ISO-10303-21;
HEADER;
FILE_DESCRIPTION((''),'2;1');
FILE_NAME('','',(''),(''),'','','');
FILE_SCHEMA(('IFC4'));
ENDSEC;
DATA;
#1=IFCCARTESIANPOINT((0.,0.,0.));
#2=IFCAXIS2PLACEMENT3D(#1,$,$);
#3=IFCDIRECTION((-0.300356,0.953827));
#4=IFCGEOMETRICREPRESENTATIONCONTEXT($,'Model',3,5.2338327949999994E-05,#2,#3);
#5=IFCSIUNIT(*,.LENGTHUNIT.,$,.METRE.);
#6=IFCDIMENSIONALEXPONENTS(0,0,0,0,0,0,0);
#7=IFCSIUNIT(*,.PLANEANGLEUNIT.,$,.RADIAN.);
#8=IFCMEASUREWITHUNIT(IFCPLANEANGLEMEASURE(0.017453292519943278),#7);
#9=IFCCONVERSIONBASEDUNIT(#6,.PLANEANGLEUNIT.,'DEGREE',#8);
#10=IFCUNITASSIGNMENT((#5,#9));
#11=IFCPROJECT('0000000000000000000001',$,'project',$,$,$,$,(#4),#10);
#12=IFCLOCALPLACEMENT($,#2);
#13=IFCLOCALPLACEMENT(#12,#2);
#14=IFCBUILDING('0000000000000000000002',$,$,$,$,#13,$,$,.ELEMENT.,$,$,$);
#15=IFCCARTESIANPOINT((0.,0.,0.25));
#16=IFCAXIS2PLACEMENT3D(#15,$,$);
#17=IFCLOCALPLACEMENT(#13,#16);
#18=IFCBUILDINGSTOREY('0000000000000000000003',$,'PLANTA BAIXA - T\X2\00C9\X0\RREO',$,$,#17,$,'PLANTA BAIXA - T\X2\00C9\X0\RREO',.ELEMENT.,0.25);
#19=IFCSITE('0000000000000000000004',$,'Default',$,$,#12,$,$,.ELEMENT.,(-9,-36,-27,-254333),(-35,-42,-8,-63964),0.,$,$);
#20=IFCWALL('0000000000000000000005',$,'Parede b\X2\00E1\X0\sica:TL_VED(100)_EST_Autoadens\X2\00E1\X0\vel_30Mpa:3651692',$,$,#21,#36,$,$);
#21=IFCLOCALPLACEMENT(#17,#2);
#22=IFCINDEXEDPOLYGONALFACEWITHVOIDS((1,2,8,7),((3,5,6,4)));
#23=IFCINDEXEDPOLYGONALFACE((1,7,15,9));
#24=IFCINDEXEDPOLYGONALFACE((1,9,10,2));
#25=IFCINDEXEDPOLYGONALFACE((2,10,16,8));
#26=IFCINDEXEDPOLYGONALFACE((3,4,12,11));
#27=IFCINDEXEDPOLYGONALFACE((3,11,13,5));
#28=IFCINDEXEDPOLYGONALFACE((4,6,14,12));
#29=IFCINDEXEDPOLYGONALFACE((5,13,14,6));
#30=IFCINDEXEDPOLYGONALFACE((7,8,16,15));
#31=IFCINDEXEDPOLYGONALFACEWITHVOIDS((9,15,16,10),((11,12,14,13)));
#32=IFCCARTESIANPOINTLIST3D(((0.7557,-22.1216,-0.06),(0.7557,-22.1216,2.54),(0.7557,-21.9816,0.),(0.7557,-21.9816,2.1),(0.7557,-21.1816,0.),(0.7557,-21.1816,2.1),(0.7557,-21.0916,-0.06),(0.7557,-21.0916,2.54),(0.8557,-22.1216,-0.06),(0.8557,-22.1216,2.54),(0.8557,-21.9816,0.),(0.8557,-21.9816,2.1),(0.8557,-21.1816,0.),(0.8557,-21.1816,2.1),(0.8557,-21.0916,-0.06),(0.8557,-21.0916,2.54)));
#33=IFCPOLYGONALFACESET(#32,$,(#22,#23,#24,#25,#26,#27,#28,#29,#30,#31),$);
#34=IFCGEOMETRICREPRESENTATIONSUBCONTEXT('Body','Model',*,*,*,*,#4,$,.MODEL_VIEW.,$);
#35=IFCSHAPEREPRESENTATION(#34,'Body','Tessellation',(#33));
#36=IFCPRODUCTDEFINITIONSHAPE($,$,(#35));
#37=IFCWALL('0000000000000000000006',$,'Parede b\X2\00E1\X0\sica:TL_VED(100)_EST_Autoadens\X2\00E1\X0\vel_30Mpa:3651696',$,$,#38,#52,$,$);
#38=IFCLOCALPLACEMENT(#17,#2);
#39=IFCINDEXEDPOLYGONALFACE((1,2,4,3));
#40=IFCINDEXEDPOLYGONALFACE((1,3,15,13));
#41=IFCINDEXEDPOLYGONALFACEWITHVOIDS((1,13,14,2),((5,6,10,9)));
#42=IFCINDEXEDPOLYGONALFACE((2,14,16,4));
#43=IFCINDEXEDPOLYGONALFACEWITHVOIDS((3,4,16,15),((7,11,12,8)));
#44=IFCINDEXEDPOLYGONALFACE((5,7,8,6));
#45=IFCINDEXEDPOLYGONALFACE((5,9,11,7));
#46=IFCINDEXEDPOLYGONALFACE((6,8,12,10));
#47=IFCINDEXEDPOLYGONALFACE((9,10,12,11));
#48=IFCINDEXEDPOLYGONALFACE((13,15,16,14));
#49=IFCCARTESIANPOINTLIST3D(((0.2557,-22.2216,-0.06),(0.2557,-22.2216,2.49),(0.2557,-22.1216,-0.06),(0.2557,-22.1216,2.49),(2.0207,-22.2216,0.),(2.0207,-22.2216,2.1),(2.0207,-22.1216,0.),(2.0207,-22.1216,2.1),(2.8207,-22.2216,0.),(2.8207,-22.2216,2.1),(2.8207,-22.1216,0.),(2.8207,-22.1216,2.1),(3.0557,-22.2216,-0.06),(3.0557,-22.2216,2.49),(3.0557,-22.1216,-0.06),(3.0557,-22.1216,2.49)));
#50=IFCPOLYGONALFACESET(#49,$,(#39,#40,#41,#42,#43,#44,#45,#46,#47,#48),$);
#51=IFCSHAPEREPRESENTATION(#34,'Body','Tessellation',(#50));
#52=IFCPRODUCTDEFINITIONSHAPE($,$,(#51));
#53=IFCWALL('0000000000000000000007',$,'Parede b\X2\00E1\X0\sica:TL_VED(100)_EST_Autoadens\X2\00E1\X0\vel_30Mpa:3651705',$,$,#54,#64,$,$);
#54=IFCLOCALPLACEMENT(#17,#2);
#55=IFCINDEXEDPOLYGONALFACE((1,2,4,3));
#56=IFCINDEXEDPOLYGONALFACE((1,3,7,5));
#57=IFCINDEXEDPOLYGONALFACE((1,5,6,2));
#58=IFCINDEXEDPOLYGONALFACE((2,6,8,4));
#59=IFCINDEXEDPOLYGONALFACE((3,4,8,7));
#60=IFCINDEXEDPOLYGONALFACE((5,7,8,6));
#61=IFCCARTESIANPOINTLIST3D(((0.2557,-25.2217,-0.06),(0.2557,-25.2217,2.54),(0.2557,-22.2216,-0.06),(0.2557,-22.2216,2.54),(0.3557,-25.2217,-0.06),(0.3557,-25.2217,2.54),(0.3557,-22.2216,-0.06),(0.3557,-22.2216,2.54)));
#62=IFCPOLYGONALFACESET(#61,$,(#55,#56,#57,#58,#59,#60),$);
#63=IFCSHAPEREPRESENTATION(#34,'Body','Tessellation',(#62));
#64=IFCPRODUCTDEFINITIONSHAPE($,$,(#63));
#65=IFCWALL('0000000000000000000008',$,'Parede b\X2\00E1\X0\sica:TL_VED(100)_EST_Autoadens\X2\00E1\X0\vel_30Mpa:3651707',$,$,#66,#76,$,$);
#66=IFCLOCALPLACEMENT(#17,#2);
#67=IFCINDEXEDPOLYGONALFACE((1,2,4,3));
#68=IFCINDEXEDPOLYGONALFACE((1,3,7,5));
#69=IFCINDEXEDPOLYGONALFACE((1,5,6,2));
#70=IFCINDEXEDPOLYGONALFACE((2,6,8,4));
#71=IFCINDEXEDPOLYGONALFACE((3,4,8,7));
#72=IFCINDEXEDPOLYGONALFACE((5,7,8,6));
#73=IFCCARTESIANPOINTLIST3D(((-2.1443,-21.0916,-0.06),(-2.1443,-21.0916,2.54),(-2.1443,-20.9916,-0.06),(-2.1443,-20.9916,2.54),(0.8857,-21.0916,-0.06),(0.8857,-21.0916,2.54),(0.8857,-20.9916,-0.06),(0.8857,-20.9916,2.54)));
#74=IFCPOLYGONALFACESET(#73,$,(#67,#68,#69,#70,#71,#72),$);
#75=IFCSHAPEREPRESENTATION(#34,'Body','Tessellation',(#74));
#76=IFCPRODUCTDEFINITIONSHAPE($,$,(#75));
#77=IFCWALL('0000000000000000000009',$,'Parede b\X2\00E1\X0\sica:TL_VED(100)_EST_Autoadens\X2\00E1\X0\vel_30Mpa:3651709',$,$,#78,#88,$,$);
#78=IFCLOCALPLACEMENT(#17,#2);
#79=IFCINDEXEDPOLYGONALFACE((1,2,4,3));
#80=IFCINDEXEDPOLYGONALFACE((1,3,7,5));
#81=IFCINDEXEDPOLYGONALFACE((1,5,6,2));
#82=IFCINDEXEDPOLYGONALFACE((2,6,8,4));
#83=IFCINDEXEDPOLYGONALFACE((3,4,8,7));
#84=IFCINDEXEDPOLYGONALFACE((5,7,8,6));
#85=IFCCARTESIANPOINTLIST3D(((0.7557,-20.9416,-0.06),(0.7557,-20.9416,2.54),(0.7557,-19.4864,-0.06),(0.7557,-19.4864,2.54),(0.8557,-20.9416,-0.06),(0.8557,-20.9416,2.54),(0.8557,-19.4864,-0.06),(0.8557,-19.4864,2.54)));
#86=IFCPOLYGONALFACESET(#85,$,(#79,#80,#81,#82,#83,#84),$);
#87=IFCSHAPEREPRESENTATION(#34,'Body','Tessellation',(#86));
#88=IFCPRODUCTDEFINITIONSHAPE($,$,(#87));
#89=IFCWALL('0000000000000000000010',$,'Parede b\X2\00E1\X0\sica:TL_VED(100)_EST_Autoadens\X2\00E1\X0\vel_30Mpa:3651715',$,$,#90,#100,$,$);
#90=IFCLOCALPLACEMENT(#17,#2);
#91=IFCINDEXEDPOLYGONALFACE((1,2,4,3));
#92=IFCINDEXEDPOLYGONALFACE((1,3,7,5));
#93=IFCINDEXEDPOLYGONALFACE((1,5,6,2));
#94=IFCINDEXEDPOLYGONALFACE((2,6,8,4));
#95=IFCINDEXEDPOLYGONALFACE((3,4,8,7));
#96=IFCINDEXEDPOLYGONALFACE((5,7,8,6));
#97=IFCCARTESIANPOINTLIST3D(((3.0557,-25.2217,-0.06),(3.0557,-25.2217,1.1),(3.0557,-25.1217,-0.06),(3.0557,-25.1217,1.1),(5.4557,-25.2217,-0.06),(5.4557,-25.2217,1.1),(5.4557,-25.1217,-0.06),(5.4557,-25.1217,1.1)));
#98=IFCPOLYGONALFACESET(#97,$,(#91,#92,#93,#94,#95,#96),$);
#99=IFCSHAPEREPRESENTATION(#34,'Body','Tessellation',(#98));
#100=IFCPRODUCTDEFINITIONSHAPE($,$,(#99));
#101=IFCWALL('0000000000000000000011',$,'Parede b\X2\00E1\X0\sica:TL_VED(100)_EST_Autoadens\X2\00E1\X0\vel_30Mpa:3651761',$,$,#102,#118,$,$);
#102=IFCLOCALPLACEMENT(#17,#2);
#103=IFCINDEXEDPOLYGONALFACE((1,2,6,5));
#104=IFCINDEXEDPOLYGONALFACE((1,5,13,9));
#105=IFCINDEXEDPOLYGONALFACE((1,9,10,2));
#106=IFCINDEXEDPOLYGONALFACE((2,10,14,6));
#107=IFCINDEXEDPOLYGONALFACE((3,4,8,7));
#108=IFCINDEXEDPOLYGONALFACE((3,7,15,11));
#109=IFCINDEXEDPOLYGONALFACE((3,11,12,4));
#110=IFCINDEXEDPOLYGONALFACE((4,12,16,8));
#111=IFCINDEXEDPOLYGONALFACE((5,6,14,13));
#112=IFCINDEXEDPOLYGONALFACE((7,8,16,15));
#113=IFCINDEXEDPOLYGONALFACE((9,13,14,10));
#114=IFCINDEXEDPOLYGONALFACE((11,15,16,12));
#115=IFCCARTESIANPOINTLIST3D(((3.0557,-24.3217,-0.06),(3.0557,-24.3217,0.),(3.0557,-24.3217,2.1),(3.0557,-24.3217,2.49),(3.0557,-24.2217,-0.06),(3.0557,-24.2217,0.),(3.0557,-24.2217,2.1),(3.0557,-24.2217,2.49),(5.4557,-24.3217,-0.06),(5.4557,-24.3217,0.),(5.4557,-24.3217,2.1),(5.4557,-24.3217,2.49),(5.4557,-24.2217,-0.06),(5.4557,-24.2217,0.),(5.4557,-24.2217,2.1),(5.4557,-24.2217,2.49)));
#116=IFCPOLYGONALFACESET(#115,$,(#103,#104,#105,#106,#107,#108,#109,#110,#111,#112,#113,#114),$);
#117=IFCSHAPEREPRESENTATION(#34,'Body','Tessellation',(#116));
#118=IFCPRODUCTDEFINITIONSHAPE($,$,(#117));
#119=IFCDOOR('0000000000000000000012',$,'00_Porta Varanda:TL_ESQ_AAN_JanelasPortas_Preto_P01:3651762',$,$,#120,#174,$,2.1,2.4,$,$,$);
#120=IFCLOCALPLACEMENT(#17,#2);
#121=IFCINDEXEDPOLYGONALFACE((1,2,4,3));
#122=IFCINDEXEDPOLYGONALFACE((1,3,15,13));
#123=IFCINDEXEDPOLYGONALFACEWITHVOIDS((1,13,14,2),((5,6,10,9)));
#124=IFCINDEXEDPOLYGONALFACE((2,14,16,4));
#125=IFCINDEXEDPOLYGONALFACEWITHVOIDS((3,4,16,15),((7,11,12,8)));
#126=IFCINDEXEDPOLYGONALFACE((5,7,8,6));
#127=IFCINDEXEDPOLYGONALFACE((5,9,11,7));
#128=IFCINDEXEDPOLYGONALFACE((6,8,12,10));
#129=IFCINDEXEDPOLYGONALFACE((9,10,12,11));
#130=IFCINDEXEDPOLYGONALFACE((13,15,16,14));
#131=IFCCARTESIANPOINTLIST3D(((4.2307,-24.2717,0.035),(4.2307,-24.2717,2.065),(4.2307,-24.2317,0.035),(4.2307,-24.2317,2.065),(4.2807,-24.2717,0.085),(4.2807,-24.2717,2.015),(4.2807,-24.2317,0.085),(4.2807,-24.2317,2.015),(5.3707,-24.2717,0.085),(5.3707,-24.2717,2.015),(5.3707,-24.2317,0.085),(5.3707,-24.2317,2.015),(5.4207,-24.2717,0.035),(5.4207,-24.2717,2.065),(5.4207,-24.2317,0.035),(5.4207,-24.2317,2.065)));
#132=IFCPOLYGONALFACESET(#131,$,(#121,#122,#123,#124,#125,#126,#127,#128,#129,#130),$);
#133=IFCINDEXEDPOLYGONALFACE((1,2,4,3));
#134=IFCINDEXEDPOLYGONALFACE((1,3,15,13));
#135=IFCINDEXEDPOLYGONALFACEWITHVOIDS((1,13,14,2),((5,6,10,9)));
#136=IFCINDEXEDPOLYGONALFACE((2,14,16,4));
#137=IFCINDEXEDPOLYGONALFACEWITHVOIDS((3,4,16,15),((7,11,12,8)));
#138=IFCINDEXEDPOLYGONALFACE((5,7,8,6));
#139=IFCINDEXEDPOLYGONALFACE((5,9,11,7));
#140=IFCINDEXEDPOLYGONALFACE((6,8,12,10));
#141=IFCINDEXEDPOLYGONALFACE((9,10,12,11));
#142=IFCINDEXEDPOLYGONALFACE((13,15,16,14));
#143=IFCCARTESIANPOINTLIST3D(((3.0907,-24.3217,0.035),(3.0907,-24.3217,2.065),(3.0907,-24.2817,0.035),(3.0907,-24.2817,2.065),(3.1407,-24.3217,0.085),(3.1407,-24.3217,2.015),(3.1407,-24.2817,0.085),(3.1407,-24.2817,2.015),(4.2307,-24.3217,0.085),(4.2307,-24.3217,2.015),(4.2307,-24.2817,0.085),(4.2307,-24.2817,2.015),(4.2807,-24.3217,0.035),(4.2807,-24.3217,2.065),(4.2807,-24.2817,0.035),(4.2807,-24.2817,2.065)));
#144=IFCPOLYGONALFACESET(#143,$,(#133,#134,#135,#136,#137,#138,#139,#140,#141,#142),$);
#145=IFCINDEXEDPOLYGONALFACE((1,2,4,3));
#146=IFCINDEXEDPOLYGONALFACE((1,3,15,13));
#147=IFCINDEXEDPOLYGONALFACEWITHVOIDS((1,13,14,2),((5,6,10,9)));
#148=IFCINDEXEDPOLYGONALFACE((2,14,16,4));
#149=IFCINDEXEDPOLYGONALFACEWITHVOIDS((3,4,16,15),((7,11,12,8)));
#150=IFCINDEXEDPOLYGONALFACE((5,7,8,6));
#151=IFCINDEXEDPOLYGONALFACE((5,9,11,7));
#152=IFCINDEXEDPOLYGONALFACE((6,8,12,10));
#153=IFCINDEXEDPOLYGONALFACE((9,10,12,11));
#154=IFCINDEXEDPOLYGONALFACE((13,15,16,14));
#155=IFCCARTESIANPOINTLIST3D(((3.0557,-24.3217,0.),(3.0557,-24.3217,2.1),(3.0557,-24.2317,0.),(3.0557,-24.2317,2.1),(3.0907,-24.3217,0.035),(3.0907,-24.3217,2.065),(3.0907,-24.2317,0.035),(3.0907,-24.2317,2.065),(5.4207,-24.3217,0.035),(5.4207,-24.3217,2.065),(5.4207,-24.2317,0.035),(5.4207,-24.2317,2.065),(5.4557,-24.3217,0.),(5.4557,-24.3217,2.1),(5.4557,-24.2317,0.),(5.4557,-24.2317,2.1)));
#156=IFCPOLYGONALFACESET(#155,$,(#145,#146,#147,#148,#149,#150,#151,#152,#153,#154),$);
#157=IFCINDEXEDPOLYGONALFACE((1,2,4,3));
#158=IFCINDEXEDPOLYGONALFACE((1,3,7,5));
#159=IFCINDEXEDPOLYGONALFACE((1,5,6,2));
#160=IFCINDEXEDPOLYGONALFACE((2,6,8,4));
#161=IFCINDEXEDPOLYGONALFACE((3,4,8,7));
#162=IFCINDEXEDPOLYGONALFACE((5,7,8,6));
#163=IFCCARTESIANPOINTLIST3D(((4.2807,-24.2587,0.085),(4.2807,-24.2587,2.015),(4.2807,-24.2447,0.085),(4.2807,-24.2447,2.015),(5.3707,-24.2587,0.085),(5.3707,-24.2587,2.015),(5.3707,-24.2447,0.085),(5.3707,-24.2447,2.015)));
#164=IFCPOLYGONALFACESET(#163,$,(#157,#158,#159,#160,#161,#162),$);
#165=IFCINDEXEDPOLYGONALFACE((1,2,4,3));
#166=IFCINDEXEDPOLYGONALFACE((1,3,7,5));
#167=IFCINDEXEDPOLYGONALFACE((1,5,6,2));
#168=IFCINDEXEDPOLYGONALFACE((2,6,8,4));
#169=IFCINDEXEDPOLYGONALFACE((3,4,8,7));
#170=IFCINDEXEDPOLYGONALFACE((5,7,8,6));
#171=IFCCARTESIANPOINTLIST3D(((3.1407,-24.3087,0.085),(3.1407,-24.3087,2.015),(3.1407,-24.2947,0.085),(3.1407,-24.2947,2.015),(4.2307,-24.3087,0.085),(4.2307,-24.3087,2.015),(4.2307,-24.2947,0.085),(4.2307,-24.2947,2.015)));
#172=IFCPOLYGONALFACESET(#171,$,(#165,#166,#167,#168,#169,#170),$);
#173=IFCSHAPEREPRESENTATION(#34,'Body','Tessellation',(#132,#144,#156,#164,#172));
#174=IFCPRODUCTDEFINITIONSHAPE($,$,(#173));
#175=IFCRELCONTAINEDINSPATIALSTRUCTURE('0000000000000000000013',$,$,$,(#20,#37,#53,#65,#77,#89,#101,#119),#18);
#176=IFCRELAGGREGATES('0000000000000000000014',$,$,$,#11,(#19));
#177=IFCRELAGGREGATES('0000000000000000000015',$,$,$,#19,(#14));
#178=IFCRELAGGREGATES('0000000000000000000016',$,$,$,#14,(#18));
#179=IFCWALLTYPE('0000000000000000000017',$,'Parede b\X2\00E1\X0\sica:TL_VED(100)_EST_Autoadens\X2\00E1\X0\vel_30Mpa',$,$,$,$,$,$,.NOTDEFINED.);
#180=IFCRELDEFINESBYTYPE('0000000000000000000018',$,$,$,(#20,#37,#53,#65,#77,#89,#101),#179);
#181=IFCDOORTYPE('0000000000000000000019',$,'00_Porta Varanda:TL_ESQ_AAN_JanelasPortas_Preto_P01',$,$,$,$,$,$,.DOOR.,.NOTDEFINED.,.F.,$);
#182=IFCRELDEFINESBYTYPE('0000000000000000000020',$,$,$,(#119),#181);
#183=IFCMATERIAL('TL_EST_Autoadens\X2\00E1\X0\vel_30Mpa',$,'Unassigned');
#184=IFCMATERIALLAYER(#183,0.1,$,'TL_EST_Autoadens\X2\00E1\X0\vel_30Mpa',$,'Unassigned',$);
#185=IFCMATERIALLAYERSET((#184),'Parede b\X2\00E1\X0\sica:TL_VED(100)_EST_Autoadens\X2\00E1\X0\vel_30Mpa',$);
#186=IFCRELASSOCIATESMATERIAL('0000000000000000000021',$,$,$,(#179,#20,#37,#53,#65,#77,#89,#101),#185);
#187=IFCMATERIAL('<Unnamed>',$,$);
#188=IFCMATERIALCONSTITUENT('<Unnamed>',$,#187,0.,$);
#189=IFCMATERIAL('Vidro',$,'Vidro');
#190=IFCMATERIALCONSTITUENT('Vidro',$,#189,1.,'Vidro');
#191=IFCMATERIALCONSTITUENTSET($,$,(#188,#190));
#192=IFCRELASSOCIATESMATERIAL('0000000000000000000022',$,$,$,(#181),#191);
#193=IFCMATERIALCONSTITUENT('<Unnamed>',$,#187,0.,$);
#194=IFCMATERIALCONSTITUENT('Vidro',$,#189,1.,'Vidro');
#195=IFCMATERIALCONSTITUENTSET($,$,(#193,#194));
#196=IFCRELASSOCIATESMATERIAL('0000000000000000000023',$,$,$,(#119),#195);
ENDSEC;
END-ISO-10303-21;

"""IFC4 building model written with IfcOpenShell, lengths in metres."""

from ifc_helpers import new_model, entity, si_unit, converted_unit, direction, frame, frame_2d, origin, place, context, subcontext, project, spatial, polyline, rectangle, outline, extrude, source, transform, mapped, material, layer, layer_set, layer_usage, constituent, constituent_set, type_object, type_shapes, element, fill, save


model = new_model("IFC4")

# Units and contexts
model_context = context("Model", 3, precision=5.2338327949999994e-05, world=origin(), true_north=direction((-0.300356, 0.953827)))
body_context = subcontext(model_context, "Body", "Model", "MODEL_VIEW")
ifc_project = project(units=[si_unit("LENGTHUNIT", "METRE"), converted_unit("PLANEANGLEUNIT", "DEGREE", entity("IfcPlaneAngleMeasure", 0.017453292519943278), si_unit("PLANEANGLEUNIT", "RADIAN"), dimensions=[0, 0, 0, 0, 0, 0, 0])], contexts=[model_context])

# Site, building, storey
site_placement = place(None, origin())
site = spatial("IfcSite", under=ifc_project, at=site_placement, Name="Default", CompositionType="ELEMENT", RefLatitude=(-9, -36, -27, -254333), RefLongitude=(-35, -42, -8, -63964), RefElevation=0.0)
building_placement = place(site_placement, origin())
building = spatial("IfcBuilding", under=site, at=building_placement, CompositionType="ELEMENT")
storey_placement = place(building_placement, frame((0.0, 0.0, 0.25)))
storey = spatial("IfcBuildingStorey", under=building, at=storey_placement, Name="PLANTA BAIXA - TÉRREO", LongName="PLANTA BAIXA - TÉRREO", CompositionType="ELEMENT", Elevation=0.25)

# Walls, openings
ifc_material_1 = material(Name="TL_EST_Autoadensável_30Mpa", Category="Unassigned")
ifc_layer_1 = layer(ifc_material_1, 0.1, Name="TL_EST_Autoadensável_30Mpa", Category="Unassigned")
ifc_layer_set_1 = layer_set([ifc_layer_1], Name="Parede básica:TL_VED(100)_EST_Autoadensável_30Mpa")
ifc_layer_usage_1 = layer_usage(ifc_layer_set_1, "AXIS2", "NEGATIVE", 0.05)
wall_type_1 = type_object("IfcWallType", Name="Parede básica:TL_VED(100)_EST_Autoadensável_30Mpa", PredefinedType="NOTDEFINED", material=ifc_layer_set_1)
wall_1_placement = place(storey_placement, frame((0.8057, -22.1216, -0.06), z_axis=(0.0, 0.0, 1.0), x_axis=(0.0, 1.0, 0.0)))
wall_1 = element("IfcWall", 1, at=wall_1_placement, inside=storey, type_object=wall_type_1, material=ifc_layer_usage_1, Name="Parede básica:TL_VED(100)_EST_Autoadensável_30Mpa:3651692", context=body_context, shape_type="SweptSolid", body=[
    extrude(rectangle(XDim=1.03, YDim=0.1, at=frame_2d((0.515, 0.0), x_axis=(-1.0, 0.0))), origin(), (0.0, 0.0, 1.0), 2.6),
])
opening_1_placement = place(wall_1_placement, frame((0.14, -0.05, 0.06)))
element("IfcOpeningElement", 2, at=opening_1_placement, cuts=wall_1, PredefinedType="OPENING", context=body_context, shape_type="SweptSolid", body=[
    extrude(rectangle(XDim=2.1, YDim=0.8, at=frame_2d((1.05, 0.4), x_axis=(1.0, 0.0))), frame((0.0, 0.0, 0.0), z_axis=(0.0, 1.0, 0.0), x_axis=(0.0, 0.0, 1.0)), (0.0, 0.0, 1.0), 0.1),
])
ifc_layer_usage_2 = layer_usage(ifc_layer_set_1, "AXIS2", "NEGATIVE", 0.05)
wall_2_placement = place(storey_placement, frame((3.0557, -22.1716, -0.06), z_axis=(0.0, 0.0, 1.0), x_axis=(-1.0, 0.0, 0.0)))
wall_2 = element("IfcWall", 3, at=wall_2_placement, inside=storey, type_object=wall_type_1, material=ifc_layer_usage_2, Name="Parede básica:TL_VED(100)_EST_Autoadensável_30Mpa:3651696", context=body_context, shape_type="SweptSolid", body=[
    extrude(rectangle(XDim=2.8, YDim=0.1, at=frame_2d((1.4, 0.0), x_axis=(-1.0, 0.0))), origin(), (0.0, 0.0, 1.0), 2.55),
])
opening_2_placement = place(wall_2_placement, frame((0.235, -0.05, 0.06)))
element("IfcOpeningElement", 4, at=opening_2_placement, cuts=wall_2, PredefinedType="OPENING", context=body_context, shape_type="SweptSolid", body=[
    extrude(rectangle(XDim=2.1, YDim=0.8, at=frame_2d((1.05, 0.4), x_axis=(1.0, 0.0))), frame((0.0, 0.0, 0.0), z_axis=(0.0, 1.0, 0.0), x_axis=(0.0, 0.0, 1.0)), (0.0, 0.0, 1.0), 0.1),
])

# Walls
ifc_layer_usage_3 = layer_usage(ifc_layer_set_1, "AXIS2", "POSITIVE", -0.05)
wall_3_placement = place(storey_placement, frame((0.3057, -25.2217, -0.06), z_axis=(0.0, 0.0, 1.0), x_axis=(0.0, 1.0, 0.0)))
element("IfcWall", 5, at=wall_3_placement, inside=storey, type_object=wall_type_1, material=ifc_layer_usage_3, Name="Parede básica:TL_VED(100)_EST_Autoadensável_30Mpa:3651705", context=body_context, shape_type="SweptSolid", body=[
    extrude(rectangle(XDim=3.0001, YDim=0.1, at=frame_2d((1.5001, 0.0), x_axis=(-1.0, 0.0))), origin(), (0.0, 0.0, 1.0), 2.6),
])
ifc_layer_usage_4 = layer_usage(ifc_layer_set_1, "AXIS2", "POSITIVE", -0.05)
wall_4_placement = place(storey_placement, frame((0.8857, -21.0416, -0.06), z_axis=(0.0, 0.0, 1.0), x_axis=(-1.0, 0.0, 0.0)))
element("IfcWall", 6, at=wall_4_placement, inside=storey, type_object=wall_type_1, material=ifc_layer_usage_4, Name="Parede básica:TL_VED(100)_EST_Autoadensável_30Mpa:3651707", context=body_context, shape_type="SweptSolid", body=[
    extrude(rectangle(XDim=3.03, YDim=0.1, at=frame_2d((1.515, 0.0), x_axis=(-1.0, 0.0))), origin(), (0.0, 0.0, 1.0), 2.6),
])
ifc_layer_usage_5 = layer_usage(ifc_layer_set_1, "AXIS2", "NEGATIVE", 0.05)
wall_5_placement = place(storey_placement, frame((0.8057, -19.4864, -0.06), z_axis=(0.0, 0.0, 1.0), x_axis=(0.0, -1.0, 0.0)))
element("IfcWall", 7, at=wall_5_placement, inside=storey, type_object=wall_type_1, material=ifc_layer_usage_5, Name="Parede básica:TL_VED(100)_EST_Autoadensável_30Mpa:3651709", context=body_context, shape_type="SweptSolid", body=[
    extrude(rectangle(XDim=1.4552, YDim=0.1, at=frame_2d((0.7276, 0.0), x_axis=(-1.0, 0.0))), origin(), (0.0, 0.0, 1.0), 2.6),
])

# Wall
ifc_layer_usage_6 = layer_usage(ifc_layer_set_1, "AXIS2", "POSITIVE", -0.05)
wall_6_placement = place(storey_placement, frame((3.0557, -25.1717, -0.06)))
element("IfcWall", 8, at=wall_6_placement, inside=storey, type_object=wall_type_1, material=ifc_layer_usage_6, Name="Parede básica:TL_VED(100)_EST_Autoadensável_30Mpa:3651715", context=body_context, shape_type="SweptSolid", body=[
    extrude(rectangle(XDim=2.4, YDim=0.1, at=frame_2d((1.2, 0.0), x_axis=(-1.0, 0.0))), origin(), (0.0, 0.0, 1.0), 1.16),
])

# Wall, opening, door
ifc_layer_usage_7 = layer_usage(ifc_layer_set_1, "AXIS2", "POSITIVE", -0.05)
wall_7_placement = place(storey_placement, frame((3.0557, -24.2717, -0.06)))
wall_7 = element("IfcWall", 9, at=wall_7_placement, inside=storey, type_object=wall_type_1, material=ifc_layer_usage_7, Name="Parede básica:TL_VED(100)_EST_Autoadensável_30Mpa:3651761", context=body_context, shape_type="SweptSolid", body=[
    extrude(rectangle(XDim=2.4, YDim=0.1, at=frame_2d((1.2, 0.0), x_axis=(-1.0, 0.0))), origin(), (0.0, 0.0, 1.0), 2.55),
])
opening_3_placement = place(wall_7_placement, frame((0.0, -0.05, 0.06)))
opening_3 = element("IfcOpeningElement", 10, at=opening_3_placement, cuts=wall_7, PredefinedType="OPENING", context=body_context, shape_type="SweptSolid", body=[
    extrude(rectangle(XDim=2.1, YDim=2.4, at=frame_2d((1.05, 1.2), x_axis=(1.0, 0.0))), frame((0.0, 0.0, 0.0), z_axis=(0.0, 1.0, 0.0), x_axis=(0.0, 0.0, 1.0)), (0.0, 0.0, 1.0), 0.1),
])
ifc_material_2 = material(Name="<Unnamed>")
ifc_constituent_1 = constituent(ifc_material_2, Name="<Unnamed>", fraction=0.0)
ifc_material_3 = material(Name="Vidro", Category="Vidro")
ifc_constituent_2 = constituent(ifc_material_3, Name="Vidro", Category="Vidro", fraction=1.0)
ifc_constituent_set_1 = constituent_set(constituents=[ifc_constituent_1, ifc_constituent_2])
ifc_constituent_3 = constituent(ifc_material_2, Name="<Unnamed>", fraction=0.0)
ifc_constituent_4 = constituent(ifc_material_3, Name="Vidro", Category="Vidro", fraction=1.0)
ifc_constituent_set_2 = constituent_set(constituents=[ifc_constituent_3, ifc_constituent_4])
door_type = type_object("IfcDoorType", Name="00_Porta Varanda:TL_ESQ_AAN_JanelasPortas_Preto_P01", OperationType="NOTDEFINED", ParameterTakesPrecedence=False, PredefinedType="DOOR", material=ifc_constituent_set_2)
shared_shape_1 = source(origin(), body_context, "Body", "SweptSolid", [
    extrude(outline(polyline([(-1.015, -0.595), (1.015, -0.595), (1.015, 0.595), (-1.015, 0.595), (-1.015, -0.595)]), holes=[polyline([(0.965, -0.545), (-0.965, -0.545), (-0.965, 0.545), (0.965, 0.545), (0.965, -0.545)])]), frame((1.77, 0.05, 1.05), z_axis=(0.0, 1.0, 0.0), x_axis=(0.0, 0.0, 1.0)), (0.0, 0.0, 1.0), 0.04),
    extrude(outline(polyline([(-1.015, -0.595), (1.015, -0.595), (1.015, 0.595), (-1.015, 0.595), (-1.015, -0.595)]), holes=[polyline([(0.965, -0.545), (-0.965, -0.545), (-0.965, 0.545), (0.965, 0.545), (0.965, -0.545)])]), frame((0.63, 0.0, 1.05), z_axis=(0.0, 1.0, 0.0), x_axis=(0.0, 0.0, -1.0)), (0.0, 0.0, 1.0), 0.04),
    extrude(outline(polyline([(-1.05, -1.2), (1.05, -1.2), (1.05, 1.2), (-1.05, 1.2), (-1.05, -1.2)]), holes=[polyline([(1.015, -1.165), (-1.015, -1.165), (-1.015, 1.165), (1.015, 1.165), (1.015, -1.165)])]), frame((1.2, 0.0, 1.05), z_axis=(0.0, 1.0, 0.0), x_axis=(0.0, 0.0, -1.0)), (0.0, 0.0, 1.0), 0.09),
    extrude(rectangle(XDim=0.014, YDim=1.09, at=frame_2d((0.0, 0.0), x_axis=(1.0, 0.0))), frame((1.77, 0.07, 0.085), z_axis=(0.0, 0.0, 1.0), x_axis=(0.0, -1.0, 0.0)), (0.0, 0.0, 1.0), 1.93),
    extrude(rectangle(XDim=0.014, YDim=1.09, at=frame_2d((0.0, 0.0), x_axis=(1.0, 0.0))), frame((0.63, 0.02, 0.085), z_axis=(0.0, 0.0, 1.0), x_axis=(0.0, -1.0, 0.0)), (0.0, 0.0, 1.0), 1.93),
])
type_shapes(door_type, [shared_shape_1])
door_placement = place(opening_3_placement, origin())
door = element("IfcDoor", 11, at=door_placement, inside=storey, type_object=door_type, material=ifc_constituent_set_1, Name="00_Porta Varanda:TL_ESQ_AAN_JanelasPortas_Preto_P01:3651762", OverallHeight=2.1, OverallWidth=2.4, context=body_context, shape_type="MappedRepresentation", body=[
    mapped(shared_shape_1, transform((0.0, 0.0, 0.0), scale=1.0)),
])
fill(opening_3, door)

save(model, "model.ifc")
